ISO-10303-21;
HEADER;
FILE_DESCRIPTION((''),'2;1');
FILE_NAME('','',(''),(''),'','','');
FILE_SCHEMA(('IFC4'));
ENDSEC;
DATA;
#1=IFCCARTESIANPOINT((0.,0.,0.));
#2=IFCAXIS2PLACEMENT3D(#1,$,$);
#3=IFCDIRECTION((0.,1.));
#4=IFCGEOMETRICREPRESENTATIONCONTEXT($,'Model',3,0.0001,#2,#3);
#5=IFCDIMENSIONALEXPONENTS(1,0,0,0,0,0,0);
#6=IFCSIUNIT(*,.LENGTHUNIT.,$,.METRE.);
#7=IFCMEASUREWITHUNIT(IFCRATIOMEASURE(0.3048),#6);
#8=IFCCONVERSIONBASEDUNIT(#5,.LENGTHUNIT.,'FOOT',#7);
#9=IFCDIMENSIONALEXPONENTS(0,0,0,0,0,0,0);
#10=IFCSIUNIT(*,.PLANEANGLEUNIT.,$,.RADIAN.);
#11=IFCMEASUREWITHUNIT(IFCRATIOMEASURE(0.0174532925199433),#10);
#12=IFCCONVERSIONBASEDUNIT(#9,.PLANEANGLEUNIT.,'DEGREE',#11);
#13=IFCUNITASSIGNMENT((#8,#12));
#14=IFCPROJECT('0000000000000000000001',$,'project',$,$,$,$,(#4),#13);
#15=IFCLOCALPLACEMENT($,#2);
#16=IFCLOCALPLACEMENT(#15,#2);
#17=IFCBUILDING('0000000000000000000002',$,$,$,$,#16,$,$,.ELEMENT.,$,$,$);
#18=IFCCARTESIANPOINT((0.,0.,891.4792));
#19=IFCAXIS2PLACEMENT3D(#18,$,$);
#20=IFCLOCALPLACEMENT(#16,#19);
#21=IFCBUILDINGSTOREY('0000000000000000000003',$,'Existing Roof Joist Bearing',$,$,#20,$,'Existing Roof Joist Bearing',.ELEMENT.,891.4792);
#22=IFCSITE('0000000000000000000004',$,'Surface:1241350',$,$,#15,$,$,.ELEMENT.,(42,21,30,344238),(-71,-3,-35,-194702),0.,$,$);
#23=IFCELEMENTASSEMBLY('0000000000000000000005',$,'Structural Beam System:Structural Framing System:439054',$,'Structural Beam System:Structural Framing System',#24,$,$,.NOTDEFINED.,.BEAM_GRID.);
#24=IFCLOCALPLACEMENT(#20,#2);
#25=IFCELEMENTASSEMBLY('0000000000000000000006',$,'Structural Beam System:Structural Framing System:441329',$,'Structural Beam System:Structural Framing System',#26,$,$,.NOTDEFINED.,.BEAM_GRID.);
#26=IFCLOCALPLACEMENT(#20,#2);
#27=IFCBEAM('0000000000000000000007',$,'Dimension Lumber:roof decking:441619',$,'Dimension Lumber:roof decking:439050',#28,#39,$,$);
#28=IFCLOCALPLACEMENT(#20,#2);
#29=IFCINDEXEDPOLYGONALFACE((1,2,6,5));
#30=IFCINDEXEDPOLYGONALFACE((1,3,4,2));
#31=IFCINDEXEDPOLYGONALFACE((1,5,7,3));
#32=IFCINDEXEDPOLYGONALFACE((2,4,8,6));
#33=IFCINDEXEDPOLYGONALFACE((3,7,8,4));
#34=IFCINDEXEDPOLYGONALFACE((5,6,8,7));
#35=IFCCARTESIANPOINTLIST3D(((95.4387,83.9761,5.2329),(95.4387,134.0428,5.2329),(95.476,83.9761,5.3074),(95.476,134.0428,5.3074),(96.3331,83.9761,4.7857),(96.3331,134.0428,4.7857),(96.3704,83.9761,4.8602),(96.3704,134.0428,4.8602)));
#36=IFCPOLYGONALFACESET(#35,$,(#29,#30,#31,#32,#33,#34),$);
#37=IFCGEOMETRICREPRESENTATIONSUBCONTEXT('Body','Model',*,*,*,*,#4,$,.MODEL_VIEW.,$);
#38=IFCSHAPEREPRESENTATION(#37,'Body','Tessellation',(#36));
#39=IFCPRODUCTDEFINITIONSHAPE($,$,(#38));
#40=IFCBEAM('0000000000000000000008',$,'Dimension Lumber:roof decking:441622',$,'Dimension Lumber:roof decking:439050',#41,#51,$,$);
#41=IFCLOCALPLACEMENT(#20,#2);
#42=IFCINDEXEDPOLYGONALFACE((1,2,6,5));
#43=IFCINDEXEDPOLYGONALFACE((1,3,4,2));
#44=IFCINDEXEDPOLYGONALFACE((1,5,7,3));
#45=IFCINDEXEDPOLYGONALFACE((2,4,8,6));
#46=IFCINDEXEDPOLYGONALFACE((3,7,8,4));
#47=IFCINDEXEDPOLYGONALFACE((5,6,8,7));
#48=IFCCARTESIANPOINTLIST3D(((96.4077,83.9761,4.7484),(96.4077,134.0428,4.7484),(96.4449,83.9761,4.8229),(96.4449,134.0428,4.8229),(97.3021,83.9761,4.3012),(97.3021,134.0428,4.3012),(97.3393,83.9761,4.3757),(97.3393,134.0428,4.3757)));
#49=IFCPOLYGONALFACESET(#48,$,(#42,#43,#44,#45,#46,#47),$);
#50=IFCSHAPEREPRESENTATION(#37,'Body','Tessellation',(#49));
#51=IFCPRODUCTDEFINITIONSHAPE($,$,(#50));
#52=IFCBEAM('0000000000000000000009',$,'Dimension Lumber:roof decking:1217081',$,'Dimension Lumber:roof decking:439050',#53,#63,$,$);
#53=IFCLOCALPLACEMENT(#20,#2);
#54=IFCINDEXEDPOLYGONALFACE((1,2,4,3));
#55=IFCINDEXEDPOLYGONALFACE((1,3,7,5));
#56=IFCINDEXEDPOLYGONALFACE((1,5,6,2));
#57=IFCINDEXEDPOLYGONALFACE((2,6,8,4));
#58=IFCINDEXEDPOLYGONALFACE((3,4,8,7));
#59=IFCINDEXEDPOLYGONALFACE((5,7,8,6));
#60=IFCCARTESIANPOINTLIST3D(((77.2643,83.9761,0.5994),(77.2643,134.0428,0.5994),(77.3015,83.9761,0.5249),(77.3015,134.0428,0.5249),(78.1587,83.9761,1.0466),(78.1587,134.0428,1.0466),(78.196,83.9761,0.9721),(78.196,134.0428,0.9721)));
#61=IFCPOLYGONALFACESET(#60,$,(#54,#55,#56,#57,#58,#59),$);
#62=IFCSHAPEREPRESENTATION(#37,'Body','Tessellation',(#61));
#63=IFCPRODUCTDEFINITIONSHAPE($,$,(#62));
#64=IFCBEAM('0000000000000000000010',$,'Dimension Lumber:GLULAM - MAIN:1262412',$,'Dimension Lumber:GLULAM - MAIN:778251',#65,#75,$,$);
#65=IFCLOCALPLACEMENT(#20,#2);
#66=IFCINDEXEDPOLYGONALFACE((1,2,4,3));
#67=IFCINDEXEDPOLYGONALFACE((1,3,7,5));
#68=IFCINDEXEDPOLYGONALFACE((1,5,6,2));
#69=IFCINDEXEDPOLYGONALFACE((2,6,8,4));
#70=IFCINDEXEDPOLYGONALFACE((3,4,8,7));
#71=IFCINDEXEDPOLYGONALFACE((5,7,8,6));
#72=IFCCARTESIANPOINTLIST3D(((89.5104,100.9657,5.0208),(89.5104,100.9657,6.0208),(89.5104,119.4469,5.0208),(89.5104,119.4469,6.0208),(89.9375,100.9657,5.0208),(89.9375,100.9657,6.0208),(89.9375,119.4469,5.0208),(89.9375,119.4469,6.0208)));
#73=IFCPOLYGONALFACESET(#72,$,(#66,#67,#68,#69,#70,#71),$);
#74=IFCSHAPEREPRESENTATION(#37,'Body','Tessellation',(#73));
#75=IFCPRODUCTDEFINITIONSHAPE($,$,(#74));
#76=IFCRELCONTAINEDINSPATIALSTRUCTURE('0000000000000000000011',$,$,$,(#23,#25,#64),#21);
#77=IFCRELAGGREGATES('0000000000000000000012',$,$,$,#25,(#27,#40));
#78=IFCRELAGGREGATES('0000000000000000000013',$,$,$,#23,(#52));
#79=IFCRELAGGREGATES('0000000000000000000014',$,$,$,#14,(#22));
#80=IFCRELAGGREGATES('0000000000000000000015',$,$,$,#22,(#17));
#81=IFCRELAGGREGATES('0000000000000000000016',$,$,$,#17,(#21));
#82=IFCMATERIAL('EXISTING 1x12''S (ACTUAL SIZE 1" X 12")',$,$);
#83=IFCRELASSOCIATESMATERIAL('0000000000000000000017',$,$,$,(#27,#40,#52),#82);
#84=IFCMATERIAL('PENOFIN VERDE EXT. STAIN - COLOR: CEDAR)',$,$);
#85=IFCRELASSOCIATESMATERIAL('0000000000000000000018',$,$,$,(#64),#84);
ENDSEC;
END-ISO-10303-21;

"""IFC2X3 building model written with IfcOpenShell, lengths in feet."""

from ifc_helpers import new_model, entity, si_unit, converted_unit, direction, frame, frame_2d, origin, place, context, subcontext, project, spatial, rectangle, extrude, material, element, aggregate, save


model = new_model("IFC2X3")

# Units and contexts
model_context = context("Model", 3, precision=0.0001, world=origin(), true_north=direction((0.0, 1.0)))
body_context = subcontext(model_context, "Body", "Model", "MODEL_VIEW")
ifc_project = project(units=[converted_unit("LENGTHUNIT", "FOOT", entity("IfcRatioMeasure", 0.3048), si_unit("LENGTHUNIT", "METRE"), dimensions=[1, 0, 0, 0, 0, 0, 0]), converted_unit("PLANEANGLEUNIT", "DEGREE", entity("IfcRatioMeasure", 0.0174532925199433), si_unit("PLANEANGLEUNIT", "RADIAN"), dimensions=[0, 0, 0, 0, 0, 0, 0])], contexts=[model_context])

# Site, building, storey
site_placement = place(None, origin())
site = spatial("IfcSite", under=ifc_project, at=site_placement, Name="Surface:1241350", CompositionType="ELEMENT", RefLatitude=(42, 21, 30, 344238), RefLongitude=(-71, -3, -35, -194702), RefElevation=0.0)
building_placement = place(site_placement, origin())
building = spatial("IfcBuilding", under=site, at=building_placement, CompositionType="ELEMENT")
storey_placement = place(building_placement, frame((0.0, 0.0, 891.4792)))
storey = spatial("IfcBuildingStorey", under=building, at=storey_placement, Name="Existing Roof Joist Bearing", LongName="Existing Roof Joist Bearing", CompositionType="ELEMENT", Elevation=891.4792)

# Element assemblies, beams
assembly_1_placement = place(storey_placement, origin())
assembly_1 = element("IfcElementAssembly", 1, at=assembly_1_placement, inside=storey, Name="Structural Beam System:Structural Framing System:439054", ObjectType="Structural Beam System:Structural Framing System", AssemblyPlace="NOTDEFINED", PredefinedType="BEAM_GRID")
ifc_material_1 = material(Name="EXISTING 1x12'S (ACTUAL SIZE 1\" X 12\")")
assembly_2_placement = place(storey_placement, origin())
assembly_2 = element("IfcElementAssembly", 2, at=assembly_2_placement, inside=storey, Name="Structural Beam System:Structural Framing System:441329", ObjectType="Structural Beam System:Structural Framing System", AssemblyPlace="NOTDEFINED", PredefinedType="BEAM_GRID")
beam_1_placement = place(assembly_2_placement, frame((95.9232, 83.9761, 5.0838), z_axis=(0.0, 0.0, 1.0), x_axis=(0.0, 1.0, 0.0)))
beam_1 = element("IfcBeam", 3, at=beam_1_placement, material=ifc_material_1, Name="Dimension Lumber:roof decking:441619", ObjectType="Dimension Lumber:roof decking:439050", context=body_context, shape_type="SweptSolid", body=[
    extrude(rectangle(XDim=0.0833, YDim=1.0, at=frame_2d((0.0, 0.0), x_axis=(0.0, 1.0))), frame((0.0, 0.0186, -0.0373), z_axis=(1.0, 0.0, 0.0), x_axis=(0.0, -0.894427, -0.447214)), (0.0, 0.0, 1.0), 50.0667),
])
beam_2_placement = place(assembly_2_placement, frame((96.8921, 83.9761, 4.5993), z_axis=(0.0, 0.0, 1.0), x_axis=(0.0, 1.0, 0.0)))
beam_2 = element("IfcBeam", 4, at=beam_2_placement, material=ifc_material_1, Name="Dimension Lumber:roof decking:441622", ObjectType="Dimension Lumber:roof decking:439050", context=body_context, shape_type="SweptSolid", body=[
    extrude(rectangle(XDim=0.0833, YDim=1.0, at=frame_2d((0.0, 0.0), x_axis=(0.0, 1.0))), frame((0.0, 0.0186, -0.0373), z_axis=(1.0, 0.0, 0.0), x_axis=(0.0, -0.894427, -0.447214)), (0.0, 0.0, 1.0), 50.0667),
])
aggregate(assembly_2, [beam_1, beam_2])

# Beams
ifc_material_2 = material(Name="PENOFIN VERDE EXT. STAIN - COLOR: CEDAR)")
beam_3_placement = place(assembly_1_placement, frame((77.7115, 83.9761, 0.823), z_axis=(0.0, 0.0, 1.0), x_axis=(0.0, 1.0, 0.0)))
beam_3 = element("IfcBeam", 5, at=beam_3_placement, material=ifc_material_1, Name="Dimension Lumber:roof decking:1217081", ObjectType="Dimension Lumber:roof decking:439050", context=body_context, shape_type="SweptSolid", body=[
    extrude(rectangle(XDim=0.0833, YDim=1.0, at=frame_2d((0.0, 0.0), x_axis=(0.0, 1.0))), frame((0.0, -0.0186, -0.0373), z_axis=(1.0, 0.0, 0.0), x_axis=(0.0, -0.894427, 0.447214)), (0.0, 0.0, 1.0), 50.0667),
])
aggregate(assembly_1, [beam_3])
beam_4_placement = place(storey_placement, frame((89.7239, 100.9657, 0.0), z_axis=(0.0, 0.0, 1.0), x_axis=(0.0, 1.0, 0.0)))
element("IfcBeam", 6, at=beam_4_placement, inside=storey, material=ifc_material_2, Name="Dimension Lumber:GLULAM - MAIN:1262412", ObjectType="Dimension Lumber:GLULAM - MAIN:778251", context=body_context, shape_type="SweptSolid", body=[
    extrude(rectangle(XDim=1.0, YDim=0.4271, at=frame_2d((0.0, 0.0), x_axis=(1.0, 0.0))), frame((0.0, 0.0, 5.5208), z_axis=(1.0, 0.0, 0.0), x_axis=(0.0, 0.0, -1.0)), (0.0, 0.0, 1.0), 18.4812),
])

save(model, "model.ifc")
